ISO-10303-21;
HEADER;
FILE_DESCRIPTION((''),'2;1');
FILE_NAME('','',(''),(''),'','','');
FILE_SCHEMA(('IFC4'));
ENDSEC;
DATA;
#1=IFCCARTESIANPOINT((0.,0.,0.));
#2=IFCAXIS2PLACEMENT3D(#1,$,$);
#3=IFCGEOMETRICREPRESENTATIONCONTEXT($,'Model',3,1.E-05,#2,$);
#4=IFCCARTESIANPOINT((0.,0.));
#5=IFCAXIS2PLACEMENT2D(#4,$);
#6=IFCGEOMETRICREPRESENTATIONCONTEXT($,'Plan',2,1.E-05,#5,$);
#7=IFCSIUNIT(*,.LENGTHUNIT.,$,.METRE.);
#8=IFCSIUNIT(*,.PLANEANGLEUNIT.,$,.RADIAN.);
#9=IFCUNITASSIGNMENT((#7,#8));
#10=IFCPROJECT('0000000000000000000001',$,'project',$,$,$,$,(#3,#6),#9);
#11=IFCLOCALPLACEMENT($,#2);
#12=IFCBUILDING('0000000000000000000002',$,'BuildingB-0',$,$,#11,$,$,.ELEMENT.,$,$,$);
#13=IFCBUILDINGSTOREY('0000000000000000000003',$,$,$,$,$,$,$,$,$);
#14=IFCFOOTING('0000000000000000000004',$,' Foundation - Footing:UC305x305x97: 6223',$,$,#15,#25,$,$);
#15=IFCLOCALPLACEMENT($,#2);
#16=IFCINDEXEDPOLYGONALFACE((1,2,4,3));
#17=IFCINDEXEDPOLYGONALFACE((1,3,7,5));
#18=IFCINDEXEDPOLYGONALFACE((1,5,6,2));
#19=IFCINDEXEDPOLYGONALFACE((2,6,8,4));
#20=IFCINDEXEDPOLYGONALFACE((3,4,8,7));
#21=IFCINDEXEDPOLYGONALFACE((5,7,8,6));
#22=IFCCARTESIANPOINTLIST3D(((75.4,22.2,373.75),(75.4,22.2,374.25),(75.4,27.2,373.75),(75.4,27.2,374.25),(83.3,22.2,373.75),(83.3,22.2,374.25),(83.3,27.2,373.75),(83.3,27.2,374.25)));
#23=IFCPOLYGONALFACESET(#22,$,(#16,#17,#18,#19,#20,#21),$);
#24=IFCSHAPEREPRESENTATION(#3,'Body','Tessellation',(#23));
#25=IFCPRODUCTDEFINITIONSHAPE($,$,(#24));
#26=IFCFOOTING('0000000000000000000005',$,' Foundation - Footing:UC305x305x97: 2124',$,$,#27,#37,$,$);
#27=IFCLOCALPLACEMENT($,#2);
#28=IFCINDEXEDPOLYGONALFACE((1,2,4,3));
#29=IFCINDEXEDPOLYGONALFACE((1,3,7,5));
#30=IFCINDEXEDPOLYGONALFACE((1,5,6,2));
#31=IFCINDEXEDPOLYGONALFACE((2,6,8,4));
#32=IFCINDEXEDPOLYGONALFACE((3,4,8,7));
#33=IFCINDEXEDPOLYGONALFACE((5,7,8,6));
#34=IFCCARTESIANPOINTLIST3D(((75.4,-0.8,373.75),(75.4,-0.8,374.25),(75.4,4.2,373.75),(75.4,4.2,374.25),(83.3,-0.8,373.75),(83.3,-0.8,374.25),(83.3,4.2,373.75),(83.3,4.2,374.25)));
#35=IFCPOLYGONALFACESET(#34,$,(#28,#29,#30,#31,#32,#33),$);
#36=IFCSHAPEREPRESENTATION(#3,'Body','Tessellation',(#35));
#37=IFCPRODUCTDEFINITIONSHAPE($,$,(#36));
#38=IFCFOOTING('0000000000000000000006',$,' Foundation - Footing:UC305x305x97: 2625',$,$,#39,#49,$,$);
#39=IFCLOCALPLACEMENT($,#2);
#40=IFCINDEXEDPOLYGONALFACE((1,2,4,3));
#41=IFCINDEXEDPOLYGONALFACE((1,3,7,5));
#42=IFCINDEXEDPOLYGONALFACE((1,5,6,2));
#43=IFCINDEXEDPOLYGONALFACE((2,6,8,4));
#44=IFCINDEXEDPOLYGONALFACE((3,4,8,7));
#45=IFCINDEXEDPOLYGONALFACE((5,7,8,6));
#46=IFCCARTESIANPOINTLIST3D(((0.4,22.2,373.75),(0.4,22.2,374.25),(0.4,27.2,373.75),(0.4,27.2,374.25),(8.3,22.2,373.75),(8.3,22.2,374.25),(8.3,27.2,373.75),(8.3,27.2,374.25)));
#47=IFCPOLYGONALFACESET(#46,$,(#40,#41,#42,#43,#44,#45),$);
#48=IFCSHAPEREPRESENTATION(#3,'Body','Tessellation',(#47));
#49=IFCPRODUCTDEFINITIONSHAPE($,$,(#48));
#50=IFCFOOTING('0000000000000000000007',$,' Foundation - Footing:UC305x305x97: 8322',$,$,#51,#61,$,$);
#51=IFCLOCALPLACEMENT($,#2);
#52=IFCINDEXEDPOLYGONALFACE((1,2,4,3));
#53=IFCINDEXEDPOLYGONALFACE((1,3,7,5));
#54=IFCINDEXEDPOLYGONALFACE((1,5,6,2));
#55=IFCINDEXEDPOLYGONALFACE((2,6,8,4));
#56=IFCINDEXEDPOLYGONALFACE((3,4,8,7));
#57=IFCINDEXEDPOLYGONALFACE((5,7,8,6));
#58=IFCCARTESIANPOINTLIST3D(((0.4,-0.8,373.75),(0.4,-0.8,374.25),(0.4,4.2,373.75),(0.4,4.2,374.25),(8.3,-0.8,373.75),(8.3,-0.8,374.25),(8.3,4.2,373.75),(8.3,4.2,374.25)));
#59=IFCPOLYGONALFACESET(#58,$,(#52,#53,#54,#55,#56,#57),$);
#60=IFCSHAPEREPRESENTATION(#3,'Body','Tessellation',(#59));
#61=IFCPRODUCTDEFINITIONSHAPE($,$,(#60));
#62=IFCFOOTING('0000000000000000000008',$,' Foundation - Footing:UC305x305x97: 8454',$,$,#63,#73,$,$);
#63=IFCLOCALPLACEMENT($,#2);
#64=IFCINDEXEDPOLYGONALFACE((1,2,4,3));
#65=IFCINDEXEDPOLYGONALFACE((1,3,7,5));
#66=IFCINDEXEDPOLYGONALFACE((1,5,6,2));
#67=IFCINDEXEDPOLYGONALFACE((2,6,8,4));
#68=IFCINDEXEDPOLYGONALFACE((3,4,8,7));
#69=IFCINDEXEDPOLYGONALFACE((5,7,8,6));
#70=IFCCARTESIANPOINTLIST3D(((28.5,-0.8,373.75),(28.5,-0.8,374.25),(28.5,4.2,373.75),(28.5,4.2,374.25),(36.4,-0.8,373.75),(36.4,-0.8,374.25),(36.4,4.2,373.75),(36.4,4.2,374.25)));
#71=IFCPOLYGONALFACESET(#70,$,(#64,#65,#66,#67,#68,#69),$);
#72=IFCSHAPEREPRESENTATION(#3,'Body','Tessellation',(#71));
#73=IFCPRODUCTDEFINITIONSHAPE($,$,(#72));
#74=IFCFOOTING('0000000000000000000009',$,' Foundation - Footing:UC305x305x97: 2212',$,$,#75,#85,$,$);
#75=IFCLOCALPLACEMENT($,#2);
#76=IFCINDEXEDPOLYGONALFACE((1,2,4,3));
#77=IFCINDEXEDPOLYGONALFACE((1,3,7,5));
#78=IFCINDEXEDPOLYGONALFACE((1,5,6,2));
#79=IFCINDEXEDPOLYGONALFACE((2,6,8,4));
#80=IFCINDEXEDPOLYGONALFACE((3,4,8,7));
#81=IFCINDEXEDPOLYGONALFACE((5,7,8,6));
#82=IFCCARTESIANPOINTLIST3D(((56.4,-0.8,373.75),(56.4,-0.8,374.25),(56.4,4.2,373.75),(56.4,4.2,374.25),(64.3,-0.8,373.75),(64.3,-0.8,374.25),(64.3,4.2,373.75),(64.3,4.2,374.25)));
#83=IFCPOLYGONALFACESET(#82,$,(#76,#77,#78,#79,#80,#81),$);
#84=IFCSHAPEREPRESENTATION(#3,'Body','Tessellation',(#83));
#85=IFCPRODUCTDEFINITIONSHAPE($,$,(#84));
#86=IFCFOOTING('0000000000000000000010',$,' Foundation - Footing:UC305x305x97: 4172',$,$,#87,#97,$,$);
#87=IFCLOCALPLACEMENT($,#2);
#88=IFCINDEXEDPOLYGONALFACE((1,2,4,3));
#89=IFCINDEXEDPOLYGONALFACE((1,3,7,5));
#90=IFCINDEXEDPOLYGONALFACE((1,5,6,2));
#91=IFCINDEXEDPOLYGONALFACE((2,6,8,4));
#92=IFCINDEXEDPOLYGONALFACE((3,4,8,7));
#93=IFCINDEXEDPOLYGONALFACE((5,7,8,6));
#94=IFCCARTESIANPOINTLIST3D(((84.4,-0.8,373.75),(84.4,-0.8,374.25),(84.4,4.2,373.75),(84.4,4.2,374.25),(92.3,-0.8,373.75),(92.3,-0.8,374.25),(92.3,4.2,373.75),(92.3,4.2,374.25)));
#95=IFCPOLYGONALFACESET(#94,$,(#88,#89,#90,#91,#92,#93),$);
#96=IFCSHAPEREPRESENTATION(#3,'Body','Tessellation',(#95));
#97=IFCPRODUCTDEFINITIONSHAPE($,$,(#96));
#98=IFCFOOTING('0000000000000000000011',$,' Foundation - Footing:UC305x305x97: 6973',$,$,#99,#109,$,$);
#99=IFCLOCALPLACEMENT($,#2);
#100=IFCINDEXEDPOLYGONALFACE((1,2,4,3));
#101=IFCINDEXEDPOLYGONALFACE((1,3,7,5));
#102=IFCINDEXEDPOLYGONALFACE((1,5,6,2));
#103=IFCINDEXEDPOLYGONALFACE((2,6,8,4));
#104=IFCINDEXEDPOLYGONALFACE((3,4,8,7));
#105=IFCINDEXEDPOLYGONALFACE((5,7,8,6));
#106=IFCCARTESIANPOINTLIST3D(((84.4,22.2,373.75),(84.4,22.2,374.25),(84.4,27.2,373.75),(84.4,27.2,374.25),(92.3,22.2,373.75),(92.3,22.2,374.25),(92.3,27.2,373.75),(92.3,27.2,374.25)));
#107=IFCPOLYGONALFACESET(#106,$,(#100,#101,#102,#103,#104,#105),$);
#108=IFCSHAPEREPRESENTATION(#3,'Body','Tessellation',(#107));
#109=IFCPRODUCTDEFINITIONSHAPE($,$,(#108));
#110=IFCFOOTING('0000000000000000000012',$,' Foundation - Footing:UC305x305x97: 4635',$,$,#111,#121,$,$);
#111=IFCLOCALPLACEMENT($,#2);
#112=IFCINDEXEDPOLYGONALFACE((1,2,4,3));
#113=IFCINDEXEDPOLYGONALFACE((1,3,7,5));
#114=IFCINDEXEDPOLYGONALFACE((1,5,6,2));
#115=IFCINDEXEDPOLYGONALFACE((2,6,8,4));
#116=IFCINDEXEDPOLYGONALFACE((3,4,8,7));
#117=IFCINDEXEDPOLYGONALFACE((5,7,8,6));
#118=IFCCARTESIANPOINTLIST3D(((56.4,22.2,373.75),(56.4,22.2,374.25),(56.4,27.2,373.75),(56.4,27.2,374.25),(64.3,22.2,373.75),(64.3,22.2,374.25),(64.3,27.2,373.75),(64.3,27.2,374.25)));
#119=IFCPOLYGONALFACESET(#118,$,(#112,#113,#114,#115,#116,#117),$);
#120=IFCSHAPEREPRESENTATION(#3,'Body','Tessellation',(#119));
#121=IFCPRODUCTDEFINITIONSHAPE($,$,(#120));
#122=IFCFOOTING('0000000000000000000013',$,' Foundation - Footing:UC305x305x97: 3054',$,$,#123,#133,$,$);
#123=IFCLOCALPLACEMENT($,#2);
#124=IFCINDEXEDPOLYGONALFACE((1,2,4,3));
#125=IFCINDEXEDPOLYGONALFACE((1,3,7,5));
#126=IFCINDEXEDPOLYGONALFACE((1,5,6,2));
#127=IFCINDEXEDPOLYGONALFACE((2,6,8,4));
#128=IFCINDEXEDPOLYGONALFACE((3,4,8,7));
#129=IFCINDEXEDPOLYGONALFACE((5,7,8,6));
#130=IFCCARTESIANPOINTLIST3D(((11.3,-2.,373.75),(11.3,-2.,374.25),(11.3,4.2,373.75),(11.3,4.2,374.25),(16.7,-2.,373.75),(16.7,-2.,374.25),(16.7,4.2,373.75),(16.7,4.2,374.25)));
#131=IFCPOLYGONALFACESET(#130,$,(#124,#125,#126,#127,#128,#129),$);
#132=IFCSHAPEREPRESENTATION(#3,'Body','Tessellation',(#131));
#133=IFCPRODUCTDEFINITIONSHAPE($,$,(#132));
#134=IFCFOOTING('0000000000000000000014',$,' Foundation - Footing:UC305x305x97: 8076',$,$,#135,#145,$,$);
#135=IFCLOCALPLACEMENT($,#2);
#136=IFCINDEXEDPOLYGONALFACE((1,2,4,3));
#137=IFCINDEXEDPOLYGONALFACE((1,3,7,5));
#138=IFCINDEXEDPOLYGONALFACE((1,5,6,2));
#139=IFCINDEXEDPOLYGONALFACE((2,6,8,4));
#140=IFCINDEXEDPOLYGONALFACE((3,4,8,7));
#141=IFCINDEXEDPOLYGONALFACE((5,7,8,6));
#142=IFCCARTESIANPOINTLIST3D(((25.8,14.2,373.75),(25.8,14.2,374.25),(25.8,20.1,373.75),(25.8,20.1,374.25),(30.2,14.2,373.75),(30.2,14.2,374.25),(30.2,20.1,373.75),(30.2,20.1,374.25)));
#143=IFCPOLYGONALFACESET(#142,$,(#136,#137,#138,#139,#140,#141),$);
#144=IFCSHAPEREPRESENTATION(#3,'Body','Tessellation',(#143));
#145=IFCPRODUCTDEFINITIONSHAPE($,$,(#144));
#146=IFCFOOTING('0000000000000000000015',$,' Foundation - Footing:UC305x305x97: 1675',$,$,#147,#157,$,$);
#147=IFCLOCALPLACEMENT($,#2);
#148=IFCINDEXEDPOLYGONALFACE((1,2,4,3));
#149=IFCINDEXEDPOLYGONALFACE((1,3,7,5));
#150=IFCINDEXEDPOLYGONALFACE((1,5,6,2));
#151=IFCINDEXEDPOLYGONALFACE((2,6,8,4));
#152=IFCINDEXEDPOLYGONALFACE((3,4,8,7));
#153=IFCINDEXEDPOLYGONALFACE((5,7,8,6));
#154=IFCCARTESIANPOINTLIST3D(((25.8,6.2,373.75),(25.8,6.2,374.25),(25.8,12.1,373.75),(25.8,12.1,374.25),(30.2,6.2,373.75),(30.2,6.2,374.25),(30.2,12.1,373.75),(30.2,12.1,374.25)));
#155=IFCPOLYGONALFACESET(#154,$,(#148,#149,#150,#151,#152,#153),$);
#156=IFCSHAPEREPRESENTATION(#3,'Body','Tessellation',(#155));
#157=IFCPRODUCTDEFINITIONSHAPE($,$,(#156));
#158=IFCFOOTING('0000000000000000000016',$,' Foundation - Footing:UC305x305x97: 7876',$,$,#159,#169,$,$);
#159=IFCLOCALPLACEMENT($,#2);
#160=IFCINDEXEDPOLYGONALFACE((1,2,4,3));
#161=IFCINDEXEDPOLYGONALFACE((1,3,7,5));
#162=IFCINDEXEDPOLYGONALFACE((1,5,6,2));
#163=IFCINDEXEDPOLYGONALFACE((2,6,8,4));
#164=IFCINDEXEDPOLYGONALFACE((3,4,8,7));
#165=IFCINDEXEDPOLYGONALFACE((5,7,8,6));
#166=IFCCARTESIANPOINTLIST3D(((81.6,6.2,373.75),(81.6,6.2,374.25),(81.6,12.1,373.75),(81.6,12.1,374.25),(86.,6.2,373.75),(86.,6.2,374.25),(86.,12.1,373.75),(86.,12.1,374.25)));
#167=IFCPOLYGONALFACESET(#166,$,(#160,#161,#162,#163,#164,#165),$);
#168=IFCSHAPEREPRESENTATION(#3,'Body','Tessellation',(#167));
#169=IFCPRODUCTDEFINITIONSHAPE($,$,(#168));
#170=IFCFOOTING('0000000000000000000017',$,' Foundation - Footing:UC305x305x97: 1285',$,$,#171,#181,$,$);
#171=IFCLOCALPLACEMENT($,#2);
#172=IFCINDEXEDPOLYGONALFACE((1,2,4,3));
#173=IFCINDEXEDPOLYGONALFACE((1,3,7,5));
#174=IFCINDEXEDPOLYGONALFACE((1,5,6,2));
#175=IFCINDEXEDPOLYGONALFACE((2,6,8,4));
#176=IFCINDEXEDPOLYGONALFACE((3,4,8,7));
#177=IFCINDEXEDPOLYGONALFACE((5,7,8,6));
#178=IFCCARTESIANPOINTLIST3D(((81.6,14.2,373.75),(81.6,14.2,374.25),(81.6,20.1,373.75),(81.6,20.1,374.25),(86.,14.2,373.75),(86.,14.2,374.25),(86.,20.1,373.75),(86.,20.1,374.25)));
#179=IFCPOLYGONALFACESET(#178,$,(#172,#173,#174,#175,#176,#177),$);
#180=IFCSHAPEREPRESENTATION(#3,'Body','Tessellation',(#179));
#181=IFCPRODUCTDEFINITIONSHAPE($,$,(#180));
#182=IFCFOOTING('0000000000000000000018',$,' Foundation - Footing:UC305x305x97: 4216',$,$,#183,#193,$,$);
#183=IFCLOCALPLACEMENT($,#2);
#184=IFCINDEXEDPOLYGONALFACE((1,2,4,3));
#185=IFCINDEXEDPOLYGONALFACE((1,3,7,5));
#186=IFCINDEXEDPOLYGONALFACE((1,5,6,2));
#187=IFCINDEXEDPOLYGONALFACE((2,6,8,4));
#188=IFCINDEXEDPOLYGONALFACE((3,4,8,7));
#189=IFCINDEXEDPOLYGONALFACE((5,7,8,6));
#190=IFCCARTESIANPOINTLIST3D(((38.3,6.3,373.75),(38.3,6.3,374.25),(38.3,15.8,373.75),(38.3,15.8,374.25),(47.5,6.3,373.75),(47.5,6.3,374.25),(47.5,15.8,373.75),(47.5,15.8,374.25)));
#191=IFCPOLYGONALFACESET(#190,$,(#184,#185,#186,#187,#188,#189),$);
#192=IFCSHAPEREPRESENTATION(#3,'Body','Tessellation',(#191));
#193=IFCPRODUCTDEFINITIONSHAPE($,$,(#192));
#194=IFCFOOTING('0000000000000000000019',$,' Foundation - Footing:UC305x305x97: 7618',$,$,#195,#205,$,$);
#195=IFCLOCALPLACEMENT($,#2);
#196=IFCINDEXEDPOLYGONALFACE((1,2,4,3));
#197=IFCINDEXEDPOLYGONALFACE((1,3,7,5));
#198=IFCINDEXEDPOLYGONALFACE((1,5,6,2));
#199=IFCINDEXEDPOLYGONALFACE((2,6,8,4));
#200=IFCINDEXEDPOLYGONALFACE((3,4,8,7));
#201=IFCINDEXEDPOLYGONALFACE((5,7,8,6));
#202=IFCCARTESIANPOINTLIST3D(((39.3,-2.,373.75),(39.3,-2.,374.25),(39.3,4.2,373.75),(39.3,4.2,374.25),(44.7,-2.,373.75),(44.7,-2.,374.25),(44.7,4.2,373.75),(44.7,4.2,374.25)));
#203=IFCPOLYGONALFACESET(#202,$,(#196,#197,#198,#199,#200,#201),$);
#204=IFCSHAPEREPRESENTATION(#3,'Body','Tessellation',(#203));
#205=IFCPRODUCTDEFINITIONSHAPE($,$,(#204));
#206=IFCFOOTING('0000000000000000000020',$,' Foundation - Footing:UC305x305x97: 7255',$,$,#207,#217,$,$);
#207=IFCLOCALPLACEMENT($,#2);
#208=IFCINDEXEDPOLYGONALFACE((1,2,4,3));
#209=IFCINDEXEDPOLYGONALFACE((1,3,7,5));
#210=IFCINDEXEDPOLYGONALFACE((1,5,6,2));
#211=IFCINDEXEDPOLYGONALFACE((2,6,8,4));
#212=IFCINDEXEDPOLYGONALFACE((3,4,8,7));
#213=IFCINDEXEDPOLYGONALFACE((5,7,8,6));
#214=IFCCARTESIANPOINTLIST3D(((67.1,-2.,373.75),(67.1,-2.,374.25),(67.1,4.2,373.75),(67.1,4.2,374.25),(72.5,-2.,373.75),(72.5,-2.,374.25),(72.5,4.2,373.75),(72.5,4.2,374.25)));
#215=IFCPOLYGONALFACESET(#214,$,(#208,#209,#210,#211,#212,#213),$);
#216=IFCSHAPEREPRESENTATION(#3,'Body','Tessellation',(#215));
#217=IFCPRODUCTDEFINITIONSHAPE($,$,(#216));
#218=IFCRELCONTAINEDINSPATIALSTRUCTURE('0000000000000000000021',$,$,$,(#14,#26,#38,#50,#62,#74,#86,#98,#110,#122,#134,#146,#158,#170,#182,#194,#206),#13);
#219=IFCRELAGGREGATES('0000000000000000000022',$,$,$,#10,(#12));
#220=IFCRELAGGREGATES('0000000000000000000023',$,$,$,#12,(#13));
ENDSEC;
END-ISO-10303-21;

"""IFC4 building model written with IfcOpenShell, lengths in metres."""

from ifc_helpers import new_model, si_unit, origin, origin_2d, place, context, project, spatial, polyline, outline, extrude, element, save


model = new_model("IFC4")

# Units and contexts
model_context = context("Model", 3, precision=1e-05, world=origin())
plan_context = context("Plan", 2, precision=1e-05, world=origin_2d())
ifc_project = project(units=[si_unit("LENGTHUNIT", "METRE"), si_unit("PLANEANGLEUNIT", "RADIAN")], contexts=[model_context, plan_context])

# Building, storey
building_placement = place(None, origin())
building = spatial("IfcBuilding", under=ifc_project, at=building_placement, Name="BuildingB-0", CompositionType="ELEMENT")
storey = spatial("IfcBuildingStorey", under=building)

# Footings
element("IfcFooting", 1, inside=storey, Name=" Foundation - Footing:UC305x305x97: 6223", context=model_context, shape_type="SweptSolid", body=[
    extrude(outline(polyline([(83.3, 27.2, 373.75), (75.4, 27.2, 373.75), (75.4, 22.2, 373.75), (83.3, 22.2, 373.75), (83.3, 27.2, 373.75)])), None, (0.0, 0.0, 1.0), 0.5),
])
element("IfcFooting", 2, inside=storey, Name=" Foundation - Footing:UC305x305x97: 2124", context=model_context, shape_type="SweptSolid", body=[
    extrude(outline(polyline([(83.3, 4.2, 373.75), (75.4, 4.2, 373.75), (75.4, -0.8, 373.75), (83.3, -0.8, 373.75), (83.3, 4.2, 373.75)])), None, (0.0, 0.0, 1.0), 0.5),
])
element("IfcFooting", 3, inside=storey, Name=" Foundation - Footing:UC305x305x97: 2625", context=model_context, shape_type="SweptSolid", body=[
    extrude(outline(polyline([(8.3, 27.2, 373.75), (0.4, 27.2, 373.75), (0.4, 22.2, 373.75), (8.3, 22.2, 373.75), (8.3, 27.2, 373.75)])), None, (0.0, 0.0, 1.0), 0.5),
])
element("IfcFooting", 4, inside=storey, Name=" Foundation - Footing:UC305x305x97: 8322", context=model_context, shape_type="SweptSolid", body=[
    extrude(outline(polyline([(8.3, 4.2, 373.75), (0.4, 4.2, 373.75), (0.4, -0.8, 373.75), (8.3, -0.8, 373.75), (8.3, 4.2, 373.75)])), None, (0.0, 0.0, 1.0), 0.5),
])
element("IfcFooting", 5, inside=storey, Name=" Foundation - Footing:UC305x305x97: 8454", context=model_context, shape_type="SweptSolid", body=[
    extrude(outline(polyline([(36.4, 4.2, 373.75), (28.5, 4.2, 373.75), (28.5, -0.8, 373.75), (36.4, -0.8, 373.75), (36.4, 4.2, 373.75)])), None, (0.0, 0.0, 1.0), 0.5),
])
element("IfcFooting", 6, inside=storey, Name=" Foundation - Footing:UC305x305x97: 2212", context=model_context, shape_type="SweptSolid", body=[
    extrude(outline(polyline([(64.3, 4.2, 373.75), (56.4, 4.2, 373.75), (56.4, -0.8, 373.75), (64.3, -0.8, 373.75), (64.3, 4.2, 373.75)])), None, (0.0, 0.0, 1.0), 0.5),
])
element("IfcFooting", 7, inside=storey, Name=" Foundation - Footing:UC305x305x97: 4172", context=model_context, shape_type="SweptSolid", body=[
    extrude(outline(polyline([(92.3, 4.2, 373.75), (84.4, 4.2, 373.75), (84.4, -0.8, 373.75), (92.3, -0.8, 373.75), (92.3, 4.2, 373.75)])), None, (0.0, 0.0, 1.0), 0.5),
])
element("IfcFooting", 8, inside=storey, Name=" Foundation - Footing:UC305x305x97: 6973", context=model_context, shape_type="SweptSolid", body=[
    extrude(outline(polyline([(92.3, 27.2, 373.75), (84.4, 27.2, 373.75), (84.4, 22.2, 373.75), (92.3, 22.2, 373.75), (92.3, 27.2, 373.75)])), None, (0.0, 0.0, 1.0), 0.5),
])
element("IfcFooting", 9, inside=storey, Name=" Foundation - Footing:UC305x305x97: 4635", context=model_context, shape_type="SweptSolid", body=[
    extrude(outline(polyline([(64.3, 27.2, 373.75), (56.4, 27.2, 373.75), (56.4, 22.2, 373.75), (64.3, 22.2, 373.75), (64.3, 27.2, 373.75)])), None, (0.0, 0.0, 1.0), 0.5),
])
element("IfcFooting", 10, inside=storey, Name=" Foundation - Footing:UC305x305x97: 3054", context=model_context, shape_type="SweptSolid", body=[
    extrude(outline(polyline([(16.7, -2.0, 373.75), (16.7, 4.2, 373.75), (11.3, 4.2, 373.75), (11.3, -2.0, 373.75), (16.7, -2.0, 373.75)])), None, (0.0, 0.0, 1.0), 0.5),
])
element("IfcFooting", 11, inside=storey, Name=" Foundation - Footing:UC305x305x97: 8076", context=model_context, shape_type="SweptSolid", body=[
    extrude(outline(polyline([(30.2, 20.1, 373.75), (25.8, 20.1, 373.75), (25.8, 14.2, 373.75), (30.2, 14.2, 373.75), (30.2, 20.1, 373.75)])), None, (0.0, 0.0, 1.0), 0.5),
])
element("IfcFooting", 12, inside=storey, Name=" Foundation - Footing:UC305x305x97: 1675", context=model_context, shape_type="SweptSolid", body=[
    extrude(outline(polyline([(30.2, 12.1, 373.75), (25.8, 12.1, 373.75), (25.8, 6.2, 373.75), (30.2, 6.2, 373.75), (30.2, 12.1, 373.75)])), None, (0.0, 0.0, 1.0), 0.5),
])
element("IfcFooting", 13, inside=storey, Name=" Foundation - Footing:UC305x305x97: 7876", context=model_context, shape_type="SweptSolid", body=[
    extrude(outline(polyline([(86.0, 12.1, 373.75), (81.6, 12.1, 373.75), (81.6, 6.2, 373.75), (86.0, 6.2, 373.75), (86.0, 12.1, 373.75)])), None, (0.0, 0.0, 1.0), 0.5),
])
element("IfcFooting", 14, inside=storey, Name=" Foundation - Footing:UC305x305x97: 1285", context=model_context, shape_type="SweptSolid", body=[
    extrude(outline(polyline([(86.0, 20.1, 373.75), (81.6, 20.1, 373.75), (81.6, 14.2, 373.75), (86.0, 14.2, 373.75), (86.0, 20.1, 373.75)])), None, (0.0, 0.0, 1.0), 0.5),
])
element("IfcFooting", 15, inside=storey, Name=" Foundation - Footing:UC305x305x97: 4216", context=model_context, shape_type="SweptSolid", body=[
    extrude(outline(polyline([(38.3, 15.8, 373.75), (47.5, 15.8, 373.75), (47.5, 6.3, 373.75), (38.3, 6.3, 373.75), (38.3, 15.8, 373.75)])), None, (0.0, 0.0, 1.0), 0.5),
])
element("IfcFooting", 16, inside=storey, Name=" Foundation - Footing:UC305x305x97: 7618", context=model_context, shape_type="SweptSolid", body=[
    extrude(outline(polyline([(44.7, -2.0, 373.75), (44.7, 4.2, 373.75), (39.3, 4.2, 373.75), (39.3, -2.0, 373.75), (44.7, -2.0, 373.75)])), None, (0.0, 0.0, 1.0), 0.5),
])
element("IfcFooting", 17, inside=storey, Name=" Foundation - Footing:UC305x305x97: 7255", context=model_context, shape_type="SweptSolid", body=[
    extrude(outline(polyline([(72.5, -2.0, 373.75), (72.5, 4.2, 373.75), (67.1, 4.2, 373.75), (67.1, -2.0, 373.75), (72.5, -2.0, 373.75)])), None, (0.0, 0.0, 1.0), 0.5),
])

save(model, "model.ifc")
